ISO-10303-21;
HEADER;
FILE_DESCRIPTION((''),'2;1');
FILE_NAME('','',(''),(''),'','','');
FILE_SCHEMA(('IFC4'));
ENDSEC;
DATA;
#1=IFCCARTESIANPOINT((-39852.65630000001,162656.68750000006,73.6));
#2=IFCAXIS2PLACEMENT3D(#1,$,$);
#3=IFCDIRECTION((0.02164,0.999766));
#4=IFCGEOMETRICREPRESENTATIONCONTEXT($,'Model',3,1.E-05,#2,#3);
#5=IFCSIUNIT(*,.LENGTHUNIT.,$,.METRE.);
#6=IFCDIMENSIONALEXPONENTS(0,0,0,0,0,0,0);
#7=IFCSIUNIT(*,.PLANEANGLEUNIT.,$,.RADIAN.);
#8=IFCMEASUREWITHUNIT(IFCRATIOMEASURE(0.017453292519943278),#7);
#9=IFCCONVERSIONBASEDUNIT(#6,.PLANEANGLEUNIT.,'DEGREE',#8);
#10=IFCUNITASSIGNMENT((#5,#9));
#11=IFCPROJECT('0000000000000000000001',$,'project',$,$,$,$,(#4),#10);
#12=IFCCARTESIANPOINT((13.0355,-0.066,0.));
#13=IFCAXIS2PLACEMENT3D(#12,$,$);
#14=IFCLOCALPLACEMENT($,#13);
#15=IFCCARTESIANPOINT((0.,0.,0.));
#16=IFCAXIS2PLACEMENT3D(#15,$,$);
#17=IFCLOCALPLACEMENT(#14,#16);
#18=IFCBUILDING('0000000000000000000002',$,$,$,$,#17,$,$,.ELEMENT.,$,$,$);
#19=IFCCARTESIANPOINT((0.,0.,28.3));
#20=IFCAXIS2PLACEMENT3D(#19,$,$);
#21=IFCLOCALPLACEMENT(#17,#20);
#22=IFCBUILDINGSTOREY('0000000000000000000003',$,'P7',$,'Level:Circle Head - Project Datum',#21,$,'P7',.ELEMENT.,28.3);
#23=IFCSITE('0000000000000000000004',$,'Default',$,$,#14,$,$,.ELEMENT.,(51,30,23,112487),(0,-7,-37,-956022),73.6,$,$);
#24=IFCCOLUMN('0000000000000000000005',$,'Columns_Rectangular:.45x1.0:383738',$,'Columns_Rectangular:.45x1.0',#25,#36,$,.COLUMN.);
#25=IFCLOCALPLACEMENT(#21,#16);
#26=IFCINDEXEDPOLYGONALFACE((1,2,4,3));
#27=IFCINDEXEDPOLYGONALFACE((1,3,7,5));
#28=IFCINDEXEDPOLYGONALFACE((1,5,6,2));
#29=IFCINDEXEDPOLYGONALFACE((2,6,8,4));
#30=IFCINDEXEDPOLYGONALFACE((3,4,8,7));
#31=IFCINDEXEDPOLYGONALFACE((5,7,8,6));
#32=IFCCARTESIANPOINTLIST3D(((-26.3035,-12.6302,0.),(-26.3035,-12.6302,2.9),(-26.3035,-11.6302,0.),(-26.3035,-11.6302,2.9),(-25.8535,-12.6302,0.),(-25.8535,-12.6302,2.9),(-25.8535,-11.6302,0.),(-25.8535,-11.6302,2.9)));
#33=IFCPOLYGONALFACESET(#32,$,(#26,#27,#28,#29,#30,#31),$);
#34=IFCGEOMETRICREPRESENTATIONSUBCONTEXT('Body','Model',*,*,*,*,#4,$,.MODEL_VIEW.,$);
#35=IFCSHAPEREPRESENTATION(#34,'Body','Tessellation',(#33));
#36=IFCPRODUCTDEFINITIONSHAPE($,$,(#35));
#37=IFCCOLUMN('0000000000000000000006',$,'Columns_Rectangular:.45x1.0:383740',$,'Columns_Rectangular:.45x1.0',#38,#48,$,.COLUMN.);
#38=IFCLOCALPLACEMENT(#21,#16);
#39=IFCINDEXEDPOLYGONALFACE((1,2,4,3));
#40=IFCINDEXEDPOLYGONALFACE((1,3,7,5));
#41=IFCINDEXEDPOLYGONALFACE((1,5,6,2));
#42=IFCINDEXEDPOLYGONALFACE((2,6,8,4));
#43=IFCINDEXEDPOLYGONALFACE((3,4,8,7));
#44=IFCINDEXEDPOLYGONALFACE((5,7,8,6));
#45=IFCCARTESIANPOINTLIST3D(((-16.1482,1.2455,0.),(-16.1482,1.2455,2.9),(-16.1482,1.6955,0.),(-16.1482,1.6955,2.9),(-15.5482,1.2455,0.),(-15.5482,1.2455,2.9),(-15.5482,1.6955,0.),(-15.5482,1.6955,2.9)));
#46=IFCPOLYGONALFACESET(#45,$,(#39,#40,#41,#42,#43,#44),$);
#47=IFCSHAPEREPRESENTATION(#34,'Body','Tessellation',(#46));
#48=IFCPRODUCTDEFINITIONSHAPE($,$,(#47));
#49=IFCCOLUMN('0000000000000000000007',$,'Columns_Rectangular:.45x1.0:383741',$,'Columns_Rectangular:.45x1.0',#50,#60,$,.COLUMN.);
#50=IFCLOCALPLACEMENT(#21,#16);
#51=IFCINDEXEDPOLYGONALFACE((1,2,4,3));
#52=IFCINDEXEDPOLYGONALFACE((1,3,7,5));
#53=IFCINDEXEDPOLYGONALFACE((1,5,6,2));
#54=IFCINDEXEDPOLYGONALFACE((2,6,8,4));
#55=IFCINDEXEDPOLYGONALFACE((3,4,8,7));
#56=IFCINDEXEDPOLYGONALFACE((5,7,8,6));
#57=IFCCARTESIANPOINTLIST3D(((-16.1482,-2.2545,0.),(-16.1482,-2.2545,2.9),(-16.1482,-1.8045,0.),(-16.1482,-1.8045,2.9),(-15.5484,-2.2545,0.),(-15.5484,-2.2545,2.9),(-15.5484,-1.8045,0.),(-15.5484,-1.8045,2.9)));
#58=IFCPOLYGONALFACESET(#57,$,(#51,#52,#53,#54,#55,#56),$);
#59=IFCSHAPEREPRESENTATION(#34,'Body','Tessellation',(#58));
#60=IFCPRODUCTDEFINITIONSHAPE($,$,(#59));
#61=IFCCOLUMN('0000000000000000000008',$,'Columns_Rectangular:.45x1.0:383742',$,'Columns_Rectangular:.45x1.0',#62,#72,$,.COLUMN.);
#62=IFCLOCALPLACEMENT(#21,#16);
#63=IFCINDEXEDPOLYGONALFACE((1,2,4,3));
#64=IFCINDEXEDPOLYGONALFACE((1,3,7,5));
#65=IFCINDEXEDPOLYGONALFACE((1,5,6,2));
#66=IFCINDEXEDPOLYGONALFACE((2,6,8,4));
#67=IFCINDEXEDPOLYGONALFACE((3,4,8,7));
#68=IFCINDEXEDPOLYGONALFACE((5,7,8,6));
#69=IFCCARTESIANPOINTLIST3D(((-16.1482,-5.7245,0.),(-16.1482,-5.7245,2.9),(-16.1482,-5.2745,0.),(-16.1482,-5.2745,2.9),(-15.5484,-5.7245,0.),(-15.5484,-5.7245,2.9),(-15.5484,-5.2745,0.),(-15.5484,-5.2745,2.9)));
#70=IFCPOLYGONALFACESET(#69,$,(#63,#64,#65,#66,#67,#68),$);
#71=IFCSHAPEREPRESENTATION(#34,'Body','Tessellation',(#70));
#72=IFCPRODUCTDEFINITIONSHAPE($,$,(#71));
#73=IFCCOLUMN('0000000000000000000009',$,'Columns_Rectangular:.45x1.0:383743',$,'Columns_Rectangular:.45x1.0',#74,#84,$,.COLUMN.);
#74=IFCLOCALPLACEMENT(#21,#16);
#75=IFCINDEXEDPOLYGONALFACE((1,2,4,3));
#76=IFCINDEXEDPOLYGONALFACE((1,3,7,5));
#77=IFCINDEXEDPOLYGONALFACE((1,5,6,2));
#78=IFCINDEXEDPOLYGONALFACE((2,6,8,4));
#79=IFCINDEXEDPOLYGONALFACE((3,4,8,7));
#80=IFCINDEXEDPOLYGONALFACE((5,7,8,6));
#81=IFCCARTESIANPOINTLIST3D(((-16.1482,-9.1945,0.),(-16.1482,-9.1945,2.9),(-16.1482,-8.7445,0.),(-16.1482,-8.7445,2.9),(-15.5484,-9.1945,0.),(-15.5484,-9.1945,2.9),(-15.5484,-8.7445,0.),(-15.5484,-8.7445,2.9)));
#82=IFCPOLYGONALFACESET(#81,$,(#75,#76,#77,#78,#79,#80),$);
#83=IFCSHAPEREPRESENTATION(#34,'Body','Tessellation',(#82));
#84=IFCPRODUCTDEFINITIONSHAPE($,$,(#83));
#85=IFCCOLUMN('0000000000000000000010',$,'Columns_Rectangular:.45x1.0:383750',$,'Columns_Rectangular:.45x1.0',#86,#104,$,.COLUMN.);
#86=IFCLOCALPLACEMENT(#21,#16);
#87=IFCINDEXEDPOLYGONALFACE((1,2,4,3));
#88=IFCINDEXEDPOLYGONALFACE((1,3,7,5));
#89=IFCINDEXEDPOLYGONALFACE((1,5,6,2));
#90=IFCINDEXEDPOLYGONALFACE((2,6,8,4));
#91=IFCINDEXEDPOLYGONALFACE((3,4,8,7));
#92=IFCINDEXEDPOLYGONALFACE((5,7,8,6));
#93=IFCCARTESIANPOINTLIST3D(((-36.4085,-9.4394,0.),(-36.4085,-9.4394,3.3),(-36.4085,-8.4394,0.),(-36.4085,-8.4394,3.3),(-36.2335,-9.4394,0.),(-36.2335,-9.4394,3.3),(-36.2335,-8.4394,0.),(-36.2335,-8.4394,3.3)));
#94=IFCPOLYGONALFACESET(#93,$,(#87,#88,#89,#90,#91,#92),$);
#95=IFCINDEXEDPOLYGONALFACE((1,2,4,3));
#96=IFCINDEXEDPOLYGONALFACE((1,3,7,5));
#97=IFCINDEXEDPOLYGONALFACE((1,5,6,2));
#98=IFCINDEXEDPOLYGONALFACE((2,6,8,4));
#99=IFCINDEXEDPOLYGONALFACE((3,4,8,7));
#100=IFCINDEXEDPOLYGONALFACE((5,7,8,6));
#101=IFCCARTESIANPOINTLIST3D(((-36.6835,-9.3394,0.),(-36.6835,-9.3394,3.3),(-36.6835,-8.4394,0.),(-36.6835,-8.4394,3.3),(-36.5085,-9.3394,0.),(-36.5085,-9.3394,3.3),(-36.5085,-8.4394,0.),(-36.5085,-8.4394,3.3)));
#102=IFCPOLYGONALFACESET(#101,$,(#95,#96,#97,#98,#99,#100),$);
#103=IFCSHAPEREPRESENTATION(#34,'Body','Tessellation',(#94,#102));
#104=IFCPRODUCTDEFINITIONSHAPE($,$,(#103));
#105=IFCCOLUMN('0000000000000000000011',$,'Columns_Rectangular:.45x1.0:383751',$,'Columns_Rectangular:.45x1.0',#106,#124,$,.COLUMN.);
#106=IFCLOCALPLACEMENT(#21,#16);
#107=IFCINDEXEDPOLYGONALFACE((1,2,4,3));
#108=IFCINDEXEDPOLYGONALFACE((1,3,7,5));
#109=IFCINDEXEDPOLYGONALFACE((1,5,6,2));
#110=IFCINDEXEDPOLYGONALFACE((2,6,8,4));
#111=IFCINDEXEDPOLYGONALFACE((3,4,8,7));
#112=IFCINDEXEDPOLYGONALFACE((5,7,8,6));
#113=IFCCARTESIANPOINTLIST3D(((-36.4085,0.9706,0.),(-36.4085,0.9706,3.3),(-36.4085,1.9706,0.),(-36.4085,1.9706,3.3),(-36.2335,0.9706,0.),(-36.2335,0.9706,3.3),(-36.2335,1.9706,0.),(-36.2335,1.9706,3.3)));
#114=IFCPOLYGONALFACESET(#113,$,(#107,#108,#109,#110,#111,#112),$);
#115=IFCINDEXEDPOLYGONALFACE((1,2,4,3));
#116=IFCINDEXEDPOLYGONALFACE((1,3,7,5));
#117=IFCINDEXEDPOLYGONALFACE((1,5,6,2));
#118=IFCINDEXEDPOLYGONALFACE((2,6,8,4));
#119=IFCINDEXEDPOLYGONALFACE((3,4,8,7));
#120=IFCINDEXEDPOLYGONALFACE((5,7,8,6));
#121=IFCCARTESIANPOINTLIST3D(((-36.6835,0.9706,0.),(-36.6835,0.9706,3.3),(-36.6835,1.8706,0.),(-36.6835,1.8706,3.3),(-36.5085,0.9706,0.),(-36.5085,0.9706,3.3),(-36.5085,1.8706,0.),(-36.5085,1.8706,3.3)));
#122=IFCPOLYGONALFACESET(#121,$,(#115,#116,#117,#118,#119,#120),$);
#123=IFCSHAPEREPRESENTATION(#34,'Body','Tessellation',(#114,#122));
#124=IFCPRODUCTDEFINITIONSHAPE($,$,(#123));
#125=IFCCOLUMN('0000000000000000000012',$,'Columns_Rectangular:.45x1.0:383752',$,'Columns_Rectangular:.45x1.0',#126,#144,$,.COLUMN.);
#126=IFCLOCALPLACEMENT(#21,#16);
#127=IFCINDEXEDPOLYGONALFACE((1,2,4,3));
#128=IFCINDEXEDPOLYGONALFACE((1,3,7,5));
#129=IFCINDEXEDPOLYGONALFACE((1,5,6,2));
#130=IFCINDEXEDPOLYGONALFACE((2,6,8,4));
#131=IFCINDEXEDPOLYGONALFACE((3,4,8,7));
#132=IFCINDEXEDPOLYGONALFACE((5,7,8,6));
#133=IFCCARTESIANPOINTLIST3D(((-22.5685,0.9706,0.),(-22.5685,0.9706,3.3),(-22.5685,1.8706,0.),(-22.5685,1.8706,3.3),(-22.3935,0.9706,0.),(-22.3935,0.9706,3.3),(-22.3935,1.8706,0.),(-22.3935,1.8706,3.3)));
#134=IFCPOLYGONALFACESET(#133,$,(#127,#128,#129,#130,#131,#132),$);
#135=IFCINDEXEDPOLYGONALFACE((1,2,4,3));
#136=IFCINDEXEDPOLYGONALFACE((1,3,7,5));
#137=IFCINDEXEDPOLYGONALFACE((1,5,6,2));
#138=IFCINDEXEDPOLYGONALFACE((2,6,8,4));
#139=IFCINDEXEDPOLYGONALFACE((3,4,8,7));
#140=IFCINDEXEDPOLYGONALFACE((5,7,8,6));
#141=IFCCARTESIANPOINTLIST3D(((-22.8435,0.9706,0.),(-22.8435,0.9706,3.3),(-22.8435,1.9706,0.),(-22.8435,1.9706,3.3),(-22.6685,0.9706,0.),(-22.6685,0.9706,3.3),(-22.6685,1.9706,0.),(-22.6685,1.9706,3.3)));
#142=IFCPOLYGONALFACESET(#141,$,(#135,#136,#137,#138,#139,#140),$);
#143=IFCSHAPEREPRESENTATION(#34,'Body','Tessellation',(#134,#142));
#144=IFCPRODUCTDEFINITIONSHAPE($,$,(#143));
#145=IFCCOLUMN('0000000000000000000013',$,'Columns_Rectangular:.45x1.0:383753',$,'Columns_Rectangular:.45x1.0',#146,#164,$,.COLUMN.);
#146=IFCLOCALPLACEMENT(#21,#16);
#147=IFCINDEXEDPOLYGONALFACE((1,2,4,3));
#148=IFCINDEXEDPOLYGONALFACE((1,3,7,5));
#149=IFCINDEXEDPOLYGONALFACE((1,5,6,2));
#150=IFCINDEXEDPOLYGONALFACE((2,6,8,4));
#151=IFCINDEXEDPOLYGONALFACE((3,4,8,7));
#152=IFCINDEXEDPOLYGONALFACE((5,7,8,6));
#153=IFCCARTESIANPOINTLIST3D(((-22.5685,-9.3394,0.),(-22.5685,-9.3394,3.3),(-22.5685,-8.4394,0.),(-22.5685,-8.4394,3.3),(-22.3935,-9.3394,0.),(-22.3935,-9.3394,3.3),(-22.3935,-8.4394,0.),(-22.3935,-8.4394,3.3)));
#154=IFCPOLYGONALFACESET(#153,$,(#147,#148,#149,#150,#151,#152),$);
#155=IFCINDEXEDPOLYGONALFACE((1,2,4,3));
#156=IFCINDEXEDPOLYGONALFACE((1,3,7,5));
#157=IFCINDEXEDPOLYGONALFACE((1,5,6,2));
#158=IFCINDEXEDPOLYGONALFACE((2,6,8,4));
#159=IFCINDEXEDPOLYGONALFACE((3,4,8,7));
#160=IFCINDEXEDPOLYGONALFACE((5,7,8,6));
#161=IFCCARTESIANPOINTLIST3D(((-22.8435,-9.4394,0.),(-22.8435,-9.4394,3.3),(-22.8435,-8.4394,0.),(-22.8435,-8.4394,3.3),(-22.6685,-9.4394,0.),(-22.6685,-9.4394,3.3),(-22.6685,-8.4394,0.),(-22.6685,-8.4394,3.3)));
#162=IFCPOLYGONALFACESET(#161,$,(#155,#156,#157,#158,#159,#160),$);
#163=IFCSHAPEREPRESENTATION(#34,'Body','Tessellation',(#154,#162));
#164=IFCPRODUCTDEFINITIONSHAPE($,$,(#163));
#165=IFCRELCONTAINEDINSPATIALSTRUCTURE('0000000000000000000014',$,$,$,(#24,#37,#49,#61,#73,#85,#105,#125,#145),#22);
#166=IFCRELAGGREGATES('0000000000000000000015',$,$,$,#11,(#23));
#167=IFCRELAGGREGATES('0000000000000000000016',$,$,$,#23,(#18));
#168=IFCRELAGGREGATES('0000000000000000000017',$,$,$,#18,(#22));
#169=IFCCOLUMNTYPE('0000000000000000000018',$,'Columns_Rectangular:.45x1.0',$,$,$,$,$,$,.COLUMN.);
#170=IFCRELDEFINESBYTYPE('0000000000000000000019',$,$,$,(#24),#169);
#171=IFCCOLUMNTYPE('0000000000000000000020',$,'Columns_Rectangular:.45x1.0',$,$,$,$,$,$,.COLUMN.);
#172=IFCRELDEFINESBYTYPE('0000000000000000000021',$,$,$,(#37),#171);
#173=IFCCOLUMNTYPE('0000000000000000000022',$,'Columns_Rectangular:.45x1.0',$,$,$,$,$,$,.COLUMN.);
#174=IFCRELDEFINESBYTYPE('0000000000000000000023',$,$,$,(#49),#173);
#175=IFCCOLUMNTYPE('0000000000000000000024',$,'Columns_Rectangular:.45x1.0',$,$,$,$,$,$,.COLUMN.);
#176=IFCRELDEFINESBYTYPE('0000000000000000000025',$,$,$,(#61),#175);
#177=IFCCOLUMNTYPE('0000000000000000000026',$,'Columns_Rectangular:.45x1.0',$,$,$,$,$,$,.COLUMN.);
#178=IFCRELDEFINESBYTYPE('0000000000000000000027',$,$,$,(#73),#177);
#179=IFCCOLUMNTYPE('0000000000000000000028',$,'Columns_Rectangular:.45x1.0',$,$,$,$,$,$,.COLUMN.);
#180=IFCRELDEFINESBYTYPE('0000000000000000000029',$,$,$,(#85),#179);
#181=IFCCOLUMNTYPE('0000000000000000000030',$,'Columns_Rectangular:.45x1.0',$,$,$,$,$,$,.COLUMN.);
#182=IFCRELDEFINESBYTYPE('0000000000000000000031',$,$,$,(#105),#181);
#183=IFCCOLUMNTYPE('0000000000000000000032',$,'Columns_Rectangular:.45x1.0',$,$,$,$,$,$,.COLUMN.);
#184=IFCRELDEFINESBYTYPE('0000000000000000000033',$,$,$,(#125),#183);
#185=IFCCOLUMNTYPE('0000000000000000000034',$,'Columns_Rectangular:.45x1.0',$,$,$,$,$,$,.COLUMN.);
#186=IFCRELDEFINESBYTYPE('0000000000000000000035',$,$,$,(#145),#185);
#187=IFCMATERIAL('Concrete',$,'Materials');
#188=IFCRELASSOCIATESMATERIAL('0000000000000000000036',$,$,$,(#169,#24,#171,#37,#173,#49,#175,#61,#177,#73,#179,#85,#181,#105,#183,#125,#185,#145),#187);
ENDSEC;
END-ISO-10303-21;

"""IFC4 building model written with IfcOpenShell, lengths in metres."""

from ifc_helpers import new_model, entity, si_unit, converted_unit, direction, frame, origin, place, context, subcontext, project, spatial, indexed_curve, outline, extrude, source, transform, mapped, material, type_object, type_shapes, element, save


model = new_model("IFC4")

# Units and contexts
model_context = context("Model", 3, precision=1e-05, world=frame((-39852.65630000001, 162656.68750000006, 73.6)), true_north=direction((0.02164, 0.999766)))
body_context = subcontext(model_context, "Body", "Model", "MODEL_VIEW")
ifc_project = project(units=[si_unit("LENGTHUNIT", "METRE"), converted_unit("PLANEANGLEUNIT", "DEGREE", entity("IfcRatioMeasure", 0.017453292519943278), si_unit("PLANEANGLEUNIT", "RADIAN"), dimensions=[0, 0, 0, 0, 0, 0, 0])], contexts=[model_context])

# Site, building, storey
site_placement = place(None, frame((13.0355, -0.066, 0.0)))
site = spatial("IfcSite", under=ifc_project, at=site_placement, Name="Default", CompositionType="ELEMENT", RefLatitude=(51, 30, 23, 112487), RefLongitude=(0, -7, -37, -956022), RefElevation=73.6)
building_placement = place(site_placement, origin())
building = spatial("IfcBuilding", under=site, at=building_placement, CompositionType="ELEMENT")
storey_placement = place(building_placement, frame((0.0, 0.0, 28.3)))
storey = spatial("IfcBuildingStorey", under=building, at=storey_placement, Name="P7", ObjectType="Level:Circle Head - Project Datum", LongName="P7", CompositionType="ELEMENT", Elevation=28.3)

# Columns
ifc_material = material(Name="Concrete", Category="Materials")
column_type_1 = type_object("IfcColumnType", Name="Columns_Rectangular:.45x1.0", PredefinedType="COLUMN", material=ifc_material)
shared_shape_1 = source(origin(), body_context, "Body", "SweptSolid", [
    extrude(outline(indexed_curve([(-0.5, -0.225), (0.5, -0.225), (0.5, 0.225), (-0.5, 0.225), (-0.5, -0.225)], self_intersect=False)), frame((-26.0785, -12.1302, 28.3), z_axis=(0.0, 0.0, 1.0), x_axis=(0.000011, 1.0, 0.0)), (0.0, 0.0, 1.0), 2.9),
])
type_shapes(column_type_1, [shared_shape_1])
column_1_placement = place(storey_placement, frame((0.0, 0.0, -28.3)))
element("IfcColumn", 1, at=column_1_placement, inside=storey, type_object=column_type_1, material=ifc_material, Name="Columns_Rectangular:.45x1.0:383738", ObjectType="Columns_Rectangular:.45x1.0", PredefinedType="COLUMN", context=body_context, shape_type="MappedRepresentation", body=[
    mapped(shared_shape_1, transform((0.0, 0.0, 0.0), scale=1.0)),
])
column_type_2 = type_object("IfcColumnType", Name="Columns_Rectangular:.45x1.0", PredefinedType="COLUMN", material=ifc_material)
shared_shape_2 = source(origin(), body_context, "Body", "SweptSolid", [
    extrude(outline(indexed_curve([(-0.225, -0.3), (0.225, -0.3), (0.225, 0.3), (-0.225, 0.3), (-0.225, -0.3)], self_intersect=False)), frame((-15.8482, 1.4705, 28.3), z_axis=(0.0, 0.0, 1.0), x_axis=(0.0, -1.0, 0.0)), (0.0, 0.0, 1.0), 2.9),
])
type_shapes(column_type_2, [shared_shape_2])
column_2_placement = place(storey_placement, frame((0.0, 0.0, -28.3)))
element("IfcColumn", 2, at=column_2_placement, inside=storey, type_object=column_type_2, material=ifc_material, Name="Columns_Rectangular:.45x1.0:383740", ObjectType="Columns_Rectangular:.45x1.0", PredefinedType="COLUMN", context=body_context, shape_type="MappedRepresentation", body=[
    mapped(shared_shape_2, transform((0.0, 0.0, 0.0), scale=1.0)),
])
column_type_3 = type_object("IfcColumnType", Name="Columns_Rectangular:.45x1.0", PredefinedType="COLUMN", material=ifc_material)
shared_shape_3 = source(origin(), body_context, "Body", "SweptSolid", [
    extrude(outline(indexed_curve([(-0.225, -0.2999), (0.225, -0.2999), (0.225, 0.2999), (-0.225, 0.2999), (-0.225, -0.2999)], self_intersect=False)), frame((-15.8483, -2.0295, 28.3), z_axis=(0.0, 0.0, 1.0), x_axis=(0.0, -1.0, 0.0)), (0.0, 0.0, 1.0), 2.9),
])
type_shapes(column_type_3, [shared_shape_3])
column_3_placement = place(storey_placement, frame((0.0, 0.0, -28.3)))
element("IfcColumn", 3, at=column_3_placement, inside=storey, type_object=column_type_3, material=ifc_material, Name="Columns_Rectangular:.45x1.0:383741", ObjectType="Columns_Rectangular:.45x1.0", PredefinedType="COLUMN", context=body_context, shape_type="MappedRepresentation", body=[
    mapped(shared_shape_3, transform((0.0, 0.0, 0.0), scale=1.0)),
])
column_type_4 = type_object("IfcColumnType", Name="Columns_Rectangular:.45x1.0", PredefinedType="COLUMN", material=ifc_material)
shared_shape_4 = source(origin(), body_context, "Body", "SweptSolid", [
    extrude(outline(indexed_curve([(-0.225, -0.2999), (0.225, -0.2999), (0.225, 0.2999), (-0.225, 0.2999), (-0.225, -0.2999)], self_intersect=False)), frame((-15.8483, -5.4995, 28.3), z_axis=(0.0, 0.0, 1.0), x_axis=(0.0, -1.0, 0.0)), (0.0, 0.0, 1.0), 2.9),
])
type_shapes(column_type_4, [shared_shape_4])
column_4_placement = place(storey_placement, frame((0.0, 0.0, -28.3)))
element("IfcColumn", 4, at=column_4_placement, inside=storey, type_object=column_type_4, material=ifc_material, Name="Columns_Rectangular:.45x1.0:383742", ObjectType="Columns_Rectangular:.45x1.0", PredefinedType="COLUMN", context=body_context, shape_type="MappedRepresentation", body=[
    mapped(shared_shape_4, transform((0.0, 0.0, 0.0), scale=1.0)),
])
column_type_5 = type_object("IfcColumnType", Name="Columns_Rectangular:.45x1.0", PredefinedType="COLUMN", material=ifc_material)
shared_shape_5 = source(origin(), body_context, "Body", "SweptSolid", [
    extrude(outline(indexed_curve([(-0.225, -0.2999), (0.225, -0.2999), (0.225, 0.2999), (-0.225, 0.2999), (-0.225, -0.2999)], self_intersect=False)), frame((-15.8483, -8.9695, 28.3), z_axis=(0.0, 0.0, 1.0), x_axis=(0.0, -1.0, 0.0)), (0.0, 0.0, 1.0), 2.9),
])
type_shapes(column_type_5, [shared_shape_5])
column_5_placement = place(storey_placement, frame((0.0, 0.0, -28.3)))
element("IfcColumn", 5, at=column_5_placement, inside=storey, type_object=column_type_5, material=ifc_material, Name="Columns_Rectangular:.45x1.0:383743", ObjectType="Columns_Rectangular:.45x1.0", PredefinedType="COLUMN", context=body_context, shape_type="MappedRepresentation", body=[
    mapped(shared_shape_5, transform((0.0, 0.0, 0.0), scale=1.0)),
])
column_type_6 = type_object("IfcColumnType", Name="Columns_Rectangular:.45x1.0", PredefinedType="COLUMN", material=ifc_material)
shared_shape_6 = source(origin(), body_context, "Body", "SweptSolid", [
    extrude(outline(indexed_curve([(-0.5, -0.0875), (0.5, -0.0875), (0.5, 0.0875), (-0.5, 0.0875), (-0.5, -0.0875)], self_intersect=False)), frame((-36.321, -8.9394, 28.3), z_axis=(0.0, 0.0, 1.0), x_axis=(0.0, -1.0, 0.0)), (0.0, 0.0, 1.0), 3.3),
    extrude(outline(indexed_curve([(-0.45, -0.0875), (0.45, -0.0875), (0.45, 0.0875), (-0.45, 0.0875), (-0.45, -0.0875)], self_intersect=False)), frame((-36.596, -8.8894, 28.3), z_axis=(0.0, 0.0, 1.0), x_axis=(0.0, -1.0, 0.0)), (0.0, 0.0, 1.0), 3.3),
])
type_shapes(column_type_6, [shared_shape_6])
column_6_placement = place(storey_placement, frame((0.0, 0.0, -28.3)))
element("IfcColumn", 6, at=column_6_placement, inside=storey, type_object=column_type_6, material=ifc_material, Name="Columns_Rectangular:.45x1.0:383750", ObjectType="Columns_Rectangular:.45x1.0", PredefinedType="COLUMN", context=body_context, shape_type="MappedRepresentation", body=[
    mapped(shared_shape_6, transform((0.0, 0.0, 0.0), scale=1.0)),
])
column_type_7 = type_object("IfcColumnType", Name="Columns_Rectangular:.45x1.0", PredefinedType="COLUMN", material=ifc_material)
shared_shape_7 = source(origin(), body_context, "Body", "SweptSolid", [
    extrude(outline(indexed_curve([(-0.5, -0.0875), (0.5, -0.0875), (0.5, 0.0875), (-0.5, 0.0875), (-0.5, -0.0875)], self_intersect=False)), frame((-36.321, 1.4706, 28.3), z_axis=(0.0, 0.0, 1.0), x_axis=(0.0, -1.0, 0.0)), (0.0, 0.0, 1.0), 3.3),
    extrude(outline(indexed_curve([(-0.45, -0.0875), (0.45, -0.0875), (0.45, 0.0875), (-0.45, 0.0875), (-0.45, -0.0875)], self_intersect=False)), frame((-36.596, 1.4206, 28.3), z_axis=(0.0, 0.0, 1.0), x_axis=(0.0, -1.0, 0.0)), (0.0, 0.0, 1.0), 3.3),
])
type_shapes(column_type_7, [shared_shape_7])
column_7_placement = place(storey_placement, frame((0.0, 0.0, -28.3)))
element("IfcColumn", 7, at=column_7_placement, inside=storey, type_object=column_type_7, material=ifc_material, Name="Columns_Rectangular:.45x1.0:383751", ObjectType="Columns_Rectangular:.45x1.0", PredefinedType="COLUMN", context=body_context, shape_type="MappedRepresentation", body=[
    mapped(shared_shape_7, transform((0.0, 0.0, 0.0), scale=1.0)),
])
column_type_8 = type_object("IfcColumnType", Name="Columns_Rectangular:.45x1.0", PredefinedType="COLUMN", material=ifc_material)
shared_shape_8 = source(origin(), body_context, "Body", "SweptSolid", [
    extrude(outline(indexed_curve([(-0.45, -0.0875), (0.45, -0.0875), (0.45, 0.0875), (-0.45, 0.0875), (-0.45, -0.0875)], self_intersect=False)), frame((-22.481, 1.4206, 28.3), z_axis=(0.0, 0.0, 1.0), x_axis=(0.0, -1.0, 0.0)), (0.0, 0.0, 1.0), 3.3),
    extrude(outline(indexed_curve([(-0.5, -0.0875), (0.5, -0.0875), (0.5, 0.0875), (-0.5, 0.0875), (-0.5, -0.0875)], self_intersect=False)), frame((-22.756, 1.4706, 28.3), z_axis=(0.0, 0.0, 1.0), x_axis=(0.0, -1.0, 0.0)), (0.0, 0.0, 1.0), 3.3),
])
type_shapes(column_type_8, [shared_shape_8])
column_8_placement = place(storey_placement, frame((0.0, 0.0, -28.3)))
element("IfcColumn", 8, at=column_8_placement, inside=storey, type_object=column_type_8, material=ifc_material, Name="Columns_Rectangular:.45x1.0:383752", ObjectType="Columns_Rectangular:.45x1.0", PredefinedType="COLUMN", context=body_context, shape_type="MappedRepresentation", body=[
    mapped(shared_shape_8, transform((0.0, 0.0, 0.0), scale=1.0)),
])
column_type_9 = type_object("IfcColumnType", Name="Columns_Rectangular:.45x1.0", PredefinedType="COLUMN", material=ifc_material)
shared_shape_9 = source(origin(), body_context, "Body", "SweptSolid", [
    extrude(outline(indexed_curve([(-0.45, -0.0875), (0.45, -0.0875), (0.45, 0.0875), (-0.45, 0.0875), (-0.45, -0.0875)], self_intersect=False)), frame((-22.481, -8.8894, 28.3), z_axis=(0.0, 0.0, 1.0), x_axis=(0.0, -1.0, 0.0)), (0.0, 0.0, 1.0), 3.3),
    extrude(outline(indexed_curve([(-0.5, -0.0875), (0.5, -0.0875), (0.5, 0.0875), (-0.5, 0.0875), (-0.5, -0.0875)], self_intersect=False)), frame((-22.756, -8.9394, 28.3), z_axis=(0.0, 0.0, 1.0), x_axis=(0.0, -1.0, 0.0)), (0.0, 0.0, 1.0), 3.3),
])
type_shapes(column_type_9, [shared_shape_9])
column_9_placement = place(storey_placement, frame((0.0, 0.0, -28.3)))
element("IfcColumn", 9, at=column_9_placement, inside=storey, type_object=column_type_9, material=ifc_material, Name="Columns_Rectangular:.45x1.0:383753", ObjectType="Columns_Rectangular:.45x1.0", PredefinedType="COLUMN", context=body_context, shape_type="MappedRepresentation", body=[
    mapped(shared_shape_9, transform((0.0, 0.0, 0.0), scale=1.0)),
])

save(model, "model.ifc")
